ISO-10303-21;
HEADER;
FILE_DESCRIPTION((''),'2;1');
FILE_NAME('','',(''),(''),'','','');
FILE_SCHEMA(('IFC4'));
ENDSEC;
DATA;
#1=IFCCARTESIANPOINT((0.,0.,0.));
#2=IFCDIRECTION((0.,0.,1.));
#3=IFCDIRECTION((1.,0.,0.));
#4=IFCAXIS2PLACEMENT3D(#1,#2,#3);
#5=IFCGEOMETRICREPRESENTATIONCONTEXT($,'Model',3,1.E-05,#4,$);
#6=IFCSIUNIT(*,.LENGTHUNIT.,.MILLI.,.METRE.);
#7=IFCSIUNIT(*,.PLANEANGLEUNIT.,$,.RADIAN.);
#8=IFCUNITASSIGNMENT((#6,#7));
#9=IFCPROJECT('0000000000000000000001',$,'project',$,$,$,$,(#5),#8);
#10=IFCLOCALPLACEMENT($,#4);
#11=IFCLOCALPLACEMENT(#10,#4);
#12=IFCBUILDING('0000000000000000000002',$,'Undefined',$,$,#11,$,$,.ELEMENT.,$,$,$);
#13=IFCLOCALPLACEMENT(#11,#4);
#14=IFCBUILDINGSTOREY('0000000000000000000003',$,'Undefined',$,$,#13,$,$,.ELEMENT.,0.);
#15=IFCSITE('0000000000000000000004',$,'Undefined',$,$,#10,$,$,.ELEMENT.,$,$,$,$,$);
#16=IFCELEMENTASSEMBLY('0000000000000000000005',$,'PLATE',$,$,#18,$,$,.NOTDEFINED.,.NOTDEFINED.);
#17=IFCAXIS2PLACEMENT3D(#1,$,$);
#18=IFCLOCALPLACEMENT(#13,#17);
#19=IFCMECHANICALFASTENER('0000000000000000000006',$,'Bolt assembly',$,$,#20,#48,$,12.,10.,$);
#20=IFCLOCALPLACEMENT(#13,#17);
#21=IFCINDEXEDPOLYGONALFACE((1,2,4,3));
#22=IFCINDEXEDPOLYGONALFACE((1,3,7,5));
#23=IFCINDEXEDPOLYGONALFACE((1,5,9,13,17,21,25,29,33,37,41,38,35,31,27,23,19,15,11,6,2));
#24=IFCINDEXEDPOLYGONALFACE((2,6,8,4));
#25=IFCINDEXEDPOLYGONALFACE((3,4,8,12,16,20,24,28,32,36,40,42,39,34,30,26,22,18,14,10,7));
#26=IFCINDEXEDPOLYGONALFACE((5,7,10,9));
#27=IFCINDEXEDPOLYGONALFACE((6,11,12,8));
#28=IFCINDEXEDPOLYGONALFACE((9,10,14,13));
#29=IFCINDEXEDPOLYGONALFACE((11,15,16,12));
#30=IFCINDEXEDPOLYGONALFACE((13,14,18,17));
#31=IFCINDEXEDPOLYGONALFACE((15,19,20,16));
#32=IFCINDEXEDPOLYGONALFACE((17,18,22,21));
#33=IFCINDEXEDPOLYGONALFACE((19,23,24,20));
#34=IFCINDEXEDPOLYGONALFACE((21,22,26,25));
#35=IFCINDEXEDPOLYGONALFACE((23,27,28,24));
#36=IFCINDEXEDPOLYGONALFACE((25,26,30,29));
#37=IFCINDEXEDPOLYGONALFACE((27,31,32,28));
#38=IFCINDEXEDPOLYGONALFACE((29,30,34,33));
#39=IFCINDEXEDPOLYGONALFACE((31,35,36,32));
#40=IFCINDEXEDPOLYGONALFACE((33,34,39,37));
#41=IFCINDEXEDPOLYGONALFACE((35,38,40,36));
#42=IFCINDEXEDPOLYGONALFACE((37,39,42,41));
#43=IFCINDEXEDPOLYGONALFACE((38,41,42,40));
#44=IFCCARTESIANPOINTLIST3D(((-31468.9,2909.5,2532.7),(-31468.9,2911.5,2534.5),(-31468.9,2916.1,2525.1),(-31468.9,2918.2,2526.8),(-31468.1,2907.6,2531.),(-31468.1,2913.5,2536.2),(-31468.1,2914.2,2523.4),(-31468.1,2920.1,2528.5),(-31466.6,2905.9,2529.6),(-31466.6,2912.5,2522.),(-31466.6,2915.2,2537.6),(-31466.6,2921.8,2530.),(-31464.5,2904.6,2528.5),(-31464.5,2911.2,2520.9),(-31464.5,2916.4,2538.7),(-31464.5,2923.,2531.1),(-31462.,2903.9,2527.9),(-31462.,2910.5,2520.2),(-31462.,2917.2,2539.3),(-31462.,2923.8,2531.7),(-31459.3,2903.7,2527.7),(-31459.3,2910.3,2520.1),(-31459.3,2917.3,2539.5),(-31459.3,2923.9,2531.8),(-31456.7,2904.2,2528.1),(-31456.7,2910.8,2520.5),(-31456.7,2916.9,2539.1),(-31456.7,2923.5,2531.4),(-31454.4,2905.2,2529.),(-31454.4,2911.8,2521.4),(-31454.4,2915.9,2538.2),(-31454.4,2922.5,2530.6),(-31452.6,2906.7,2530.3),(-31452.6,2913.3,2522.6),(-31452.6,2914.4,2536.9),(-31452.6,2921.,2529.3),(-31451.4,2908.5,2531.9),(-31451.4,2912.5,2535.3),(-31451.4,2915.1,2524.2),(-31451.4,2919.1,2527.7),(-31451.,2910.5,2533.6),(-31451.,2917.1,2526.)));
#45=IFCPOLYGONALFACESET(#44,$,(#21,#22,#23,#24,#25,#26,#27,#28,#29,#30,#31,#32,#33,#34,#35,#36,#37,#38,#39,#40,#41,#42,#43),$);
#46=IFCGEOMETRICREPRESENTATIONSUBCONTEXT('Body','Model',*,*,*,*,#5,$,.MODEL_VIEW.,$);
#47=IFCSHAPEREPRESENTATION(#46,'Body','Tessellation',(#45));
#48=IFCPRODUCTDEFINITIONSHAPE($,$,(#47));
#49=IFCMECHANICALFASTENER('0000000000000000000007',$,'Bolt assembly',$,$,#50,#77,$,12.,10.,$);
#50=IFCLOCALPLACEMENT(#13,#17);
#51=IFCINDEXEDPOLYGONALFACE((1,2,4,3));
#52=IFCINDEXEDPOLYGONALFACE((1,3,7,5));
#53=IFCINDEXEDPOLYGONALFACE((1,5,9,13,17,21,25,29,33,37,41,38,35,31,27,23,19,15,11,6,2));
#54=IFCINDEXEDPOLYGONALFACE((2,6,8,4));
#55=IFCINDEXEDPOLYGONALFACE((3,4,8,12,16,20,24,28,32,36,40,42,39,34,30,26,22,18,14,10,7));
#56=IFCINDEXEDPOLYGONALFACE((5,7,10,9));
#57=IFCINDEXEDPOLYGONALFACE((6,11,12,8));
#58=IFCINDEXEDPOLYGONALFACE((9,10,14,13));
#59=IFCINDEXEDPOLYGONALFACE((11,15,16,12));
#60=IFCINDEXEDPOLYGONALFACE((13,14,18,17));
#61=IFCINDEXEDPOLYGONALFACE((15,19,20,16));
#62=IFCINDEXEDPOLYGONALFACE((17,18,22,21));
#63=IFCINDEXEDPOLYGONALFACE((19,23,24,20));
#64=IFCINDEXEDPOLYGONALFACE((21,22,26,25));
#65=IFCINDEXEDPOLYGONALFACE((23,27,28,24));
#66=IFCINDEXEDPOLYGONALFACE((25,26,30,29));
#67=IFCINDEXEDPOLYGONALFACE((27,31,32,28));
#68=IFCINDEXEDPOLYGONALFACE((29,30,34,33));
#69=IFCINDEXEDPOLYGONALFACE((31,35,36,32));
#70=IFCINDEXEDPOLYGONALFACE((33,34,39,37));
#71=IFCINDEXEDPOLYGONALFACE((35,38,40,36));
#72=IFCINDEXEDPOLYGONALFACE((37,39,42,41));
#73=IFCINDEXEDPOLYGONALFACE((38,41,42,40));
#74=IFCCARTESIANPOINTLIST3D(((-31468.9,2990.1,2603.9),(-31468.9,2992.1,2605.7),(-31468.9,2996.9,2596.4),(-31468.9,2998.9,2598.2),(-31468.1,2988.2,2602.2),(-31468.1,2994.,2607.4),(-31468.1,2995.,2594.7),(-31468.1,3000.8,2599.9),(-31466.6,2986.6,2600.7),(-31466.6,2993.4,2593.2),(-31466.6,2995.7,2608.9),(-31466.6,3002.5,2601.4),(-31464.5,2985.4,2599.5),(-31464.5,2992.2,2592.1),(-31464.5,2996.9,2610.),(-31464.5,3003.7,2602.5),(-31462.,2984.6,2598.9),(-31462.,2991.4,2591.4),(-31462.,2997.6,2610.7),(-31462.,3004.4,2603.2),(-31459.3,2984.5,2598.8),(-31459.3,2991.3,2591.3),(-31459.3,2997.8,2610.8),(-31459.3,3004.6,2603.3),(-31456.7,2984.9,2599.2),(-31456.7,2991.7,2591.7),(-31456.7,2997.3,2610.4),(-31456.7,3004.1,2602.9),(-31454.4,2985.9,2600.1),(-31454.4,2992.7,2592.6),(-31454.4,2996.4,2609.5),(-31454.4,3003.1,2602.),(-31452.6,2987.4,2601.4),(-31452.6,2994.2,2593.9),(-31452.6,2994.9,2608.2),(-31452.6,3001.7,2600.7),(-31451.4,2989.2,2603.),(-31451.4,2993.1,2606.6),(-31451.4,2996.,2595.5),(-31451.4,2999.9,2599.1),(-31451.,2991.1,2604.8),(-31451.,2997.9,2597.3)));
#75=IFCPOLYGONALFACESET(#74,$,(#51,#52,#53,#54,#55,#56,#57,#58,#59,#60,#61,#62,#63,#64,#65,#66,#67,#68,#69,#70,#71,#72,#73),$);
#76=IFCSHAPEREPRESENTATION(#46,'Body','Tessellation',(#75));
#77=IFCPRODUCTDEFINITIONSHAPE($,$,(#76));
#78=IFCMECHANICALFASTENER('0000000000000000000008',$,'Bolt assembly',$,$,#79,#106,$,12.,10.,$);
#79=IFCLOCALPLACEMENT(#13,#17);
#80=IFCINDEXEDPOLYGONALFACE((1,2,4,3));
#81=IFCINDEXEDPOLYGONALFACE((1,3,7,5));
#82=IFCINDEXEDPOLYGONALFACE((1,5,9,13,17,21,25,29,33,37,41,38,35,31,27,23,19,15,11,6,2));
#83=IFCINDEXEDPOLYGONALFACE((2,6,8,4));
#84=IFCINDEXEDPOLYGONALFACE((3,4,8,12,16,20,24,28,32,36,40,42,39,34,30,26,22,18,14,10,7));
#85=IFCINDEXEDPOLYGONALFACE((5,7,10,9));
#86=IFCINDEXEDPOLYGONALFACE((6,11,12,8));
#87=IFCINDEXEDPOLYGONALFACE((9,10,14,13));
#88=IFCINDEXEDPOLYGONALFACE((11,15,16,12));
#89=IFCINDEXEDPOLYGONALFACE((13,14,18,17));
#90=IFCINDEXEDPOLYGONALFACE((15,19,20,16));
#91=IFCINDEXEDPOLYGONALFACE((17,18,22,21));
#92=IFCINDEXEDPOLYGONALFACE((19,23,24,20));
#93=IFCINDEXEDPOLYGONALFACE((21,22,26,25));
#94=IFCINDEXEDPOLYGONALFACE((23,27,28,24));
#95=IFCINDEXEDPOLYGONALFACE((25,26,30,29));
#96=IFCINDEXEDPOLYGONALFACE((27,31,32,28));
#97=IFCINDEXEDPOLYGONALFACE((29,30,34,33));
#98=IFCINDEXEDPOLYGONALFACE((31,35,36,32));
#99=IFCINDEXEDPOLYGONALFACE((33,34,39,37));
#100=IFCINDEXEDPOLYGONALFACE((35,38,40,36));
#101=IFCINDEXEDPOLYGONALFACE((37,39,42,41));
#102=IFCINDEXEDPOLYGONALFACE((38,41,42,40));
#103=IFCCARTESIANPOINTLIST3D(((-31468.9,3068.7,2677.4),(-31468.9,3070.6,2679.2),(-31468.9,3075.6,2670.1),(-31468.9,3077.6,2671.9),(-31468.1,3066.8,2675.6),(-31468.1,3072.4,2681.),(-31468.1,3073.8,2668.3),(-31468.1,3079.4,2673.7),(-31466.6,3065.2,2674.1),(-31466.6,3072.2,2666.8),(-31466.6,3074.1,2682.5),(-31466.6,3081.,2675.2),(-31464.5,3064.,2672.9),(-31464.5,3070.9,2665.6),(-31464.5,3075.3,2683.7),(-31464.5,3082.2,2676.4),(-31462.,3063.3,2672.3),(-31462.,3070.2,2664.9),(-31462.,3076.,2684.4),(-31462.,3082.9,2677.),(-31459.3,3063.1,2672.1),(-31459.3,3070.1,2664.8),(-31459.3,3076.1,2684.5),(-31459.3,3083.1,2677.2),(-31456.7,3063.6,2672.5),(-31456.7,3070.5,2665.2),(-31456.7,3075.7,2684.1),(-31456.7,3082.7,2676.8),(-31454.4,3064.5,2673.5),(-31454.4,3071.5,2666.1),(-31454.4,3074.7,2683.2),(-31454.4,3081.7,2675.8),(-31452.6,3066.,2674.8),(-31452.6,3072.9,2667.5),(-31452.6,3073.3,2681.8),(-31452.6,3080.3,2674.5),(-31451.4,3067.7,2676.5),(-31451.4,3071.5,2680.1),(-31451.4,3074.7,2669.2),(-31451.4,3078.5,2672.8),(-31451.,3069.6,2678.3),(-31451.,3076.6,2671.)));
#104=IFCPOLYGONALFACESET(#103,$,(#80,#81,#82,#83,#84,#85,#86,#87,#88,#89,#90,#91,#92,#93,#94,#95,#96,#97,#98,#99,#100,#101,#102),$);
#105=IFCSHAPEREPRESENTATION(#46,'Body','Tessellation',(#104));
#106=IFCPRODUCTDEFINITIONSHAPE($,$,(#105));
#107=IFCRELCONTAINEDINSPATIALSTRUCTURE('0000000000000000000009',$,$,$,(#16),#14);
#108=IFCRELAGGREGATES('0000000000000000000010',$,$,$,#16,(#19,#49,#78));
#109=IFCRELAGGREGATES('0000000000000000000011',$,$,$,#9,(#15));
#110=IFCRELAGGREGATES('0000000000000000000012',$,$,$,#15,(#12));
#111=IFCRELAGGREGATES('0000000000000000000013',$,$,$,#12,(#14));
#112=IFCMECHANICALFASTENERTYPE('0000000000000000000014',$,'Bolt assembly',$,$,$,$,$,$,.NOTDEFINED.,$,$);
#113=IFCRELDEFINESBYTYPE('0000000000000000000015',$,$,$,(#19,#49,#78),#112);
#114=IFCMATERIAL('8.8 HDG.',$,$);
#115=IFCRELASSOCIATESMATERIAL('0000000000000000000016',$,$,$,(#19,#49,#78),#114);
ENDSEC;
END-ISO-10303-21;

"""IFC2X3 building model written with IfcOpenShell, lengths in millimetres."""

from ifc_helpers import new_model, si_unit, frame, origin_with_axes, origin_2d_with_axis, place, context, subcontext, project, spatial, circle, extrude, source, transform, mapped, material, type_object, element, aggregate, save


model = new_model("IFC2X3")

# Units and contexts
model_context = context("Model", 3, precision=1e-05, world=origin_with_axes())
body_context = subcontext(model_context, "Body", "Model", "MODEL_VIEW")
ifc_project = project(units=[si_unit("LENGTHUNIT", "METRE", prefix="MILLI"), si_unit("PLANEANGLEUNIT", "RADIAN")], contexts=[model_context])

# Site, building, storey
site_placement = place(None, origin_with_axes())
site = spatial("IfcSite", under=ifc_project, at=site_placement, Name="Undefined", CompositionType="ELEMENT")
building_placement = place(site_placement, origin_with_axes())
building = spatial("IfcBuilding", under=site, at=building_placement, Name="Undefined", CompositionType="ELEMENT")
storey_placement = place(building_placement, origin_with_axes())
storey = spatial("IfcBuildingStorey", under=building, at=storey_placement, Name="Undefined", CompositionType="ELEMENT", Elevation=0.0)

# Element assembly, mechanical fasteners
assembly_placement = place(storey_placement, origin_with_axes())
assembly = element("IfcElementAssembly", 1, at=assembly_placement, inside=storey, Name="PLATE", AssemblyPlace="NOTDEFINED", PredefinedType="NOTDEFINED")
ifc_material_1 = material(Name="8.8 HDG.")
mechanical_fastener_type = type_object("IfcMechanicalFastenerType", Name="Bolt assembly")
shared_shape_1 = source(origin_with_axes(), body_context, "Body", "SweptSolid", [
    extrude(circle(Radius=9.0, at=origin_2d_with_axis()), frame((0.0, 0.7, 0.0), z_axis=(0.0, 1.0, 0.0), x_axis=(1.0, 0.0, 0.0)), (0.0, 0.0, 1.0), 10.1),
])
mechanical_fastener_1_placement = place(assembly_placement, frame((-31460.0, 2917.6, 2525.4), z_axis=(0.000001, -0.756468, -0.65403), x_axis=(1.0, 0.000001, 0.000001)))
mechanical_fastener_1 = element("IfcMechanicalFastener", 2, at=mechanical_fastener_1_placement, type_object=mechanical_fastener_type, material=ifc_material_1, Name="Bolt assembly", NominalDiameter=12.0, NominalLength=10.0, context=body_context, shape_type="MappedRepresentation", body=[
    mapped(shared_shape_1, transform((0.0, 0.0, 0.0))),
])
shared_shape_2 = source(origin_with_axes(), body_context, "Body", "SweptSolid", [
    extrude(circle(Radius=9.0, at=origin_2d_with_axis()), frame((0.0, 0.5, 0.0), z_axis=(0.0, 1.0, 0.0), x_axis=(1.0, 0.0, 0.0)), (0.0, 0.0, 1.0), 10.1),
])
mechanical_fastener_2_placement = place(assembly_placement, frame((-31460.0, 2998.3, 2596.9), z_axis=(0.000001, -0.740444, -0.672118), x_axis=(1.0, 0.000001, 0.000001)))
mechanical_fastener_2 = element("IfcMechanicalFastener", 3, at=mechanical_fastener_2_placement, type_object=mechanical_fastener_type, material=ifc_material_1, Name="Bolt assembly", NominalDiameter=12.0, NominalLength=10.0, context=body_context, shape_type="MappedRepresentation", body=[
    mapped(shared_shape_2, transform((0.0, 0.0, 0.0))),
])
shared_shape_3 = source(origin_with_axes(), body_context, "Body", "SweptSolid", [
    extrude(circle(Radius=9.0, at=origin_2d_with_axis()), frame((0.0, 0.9, 0.0), z_axis=(0.0, 1.0, 0.0), x_axis=(1.0, 0.0, 0.0)), (0.0, 0.0, 1.0), 10.1),
])
mechanical_fastener_3_placement = place(assembly_placement, frame((-31460.0, 3077.2, 2670.3), z_axis=(0.000001, -0.723987, -0.689814), x_axis=(1.0, 0.000001, 0.000001)))
mechanical_fastener_3 = element("IfcMechanicalFastener", 4, at=mechanical_fastener_3_placement, type_object=mechanical_fastener_type, material=ifc_material_1, Name="Bolt assembly", NominalDiameter=12.0, NominalLength=10.0, context=body_context, shape_type="MappedRepresentation", body=[
    mapped(shared_shape_3, transform((0.0, 0.0, 0.0))),
])
aggregate(assembly, [mechanical_fastener_1, mechanical_fastener_2, mechanical_fastener_3])

save(model, "model.ifc")
